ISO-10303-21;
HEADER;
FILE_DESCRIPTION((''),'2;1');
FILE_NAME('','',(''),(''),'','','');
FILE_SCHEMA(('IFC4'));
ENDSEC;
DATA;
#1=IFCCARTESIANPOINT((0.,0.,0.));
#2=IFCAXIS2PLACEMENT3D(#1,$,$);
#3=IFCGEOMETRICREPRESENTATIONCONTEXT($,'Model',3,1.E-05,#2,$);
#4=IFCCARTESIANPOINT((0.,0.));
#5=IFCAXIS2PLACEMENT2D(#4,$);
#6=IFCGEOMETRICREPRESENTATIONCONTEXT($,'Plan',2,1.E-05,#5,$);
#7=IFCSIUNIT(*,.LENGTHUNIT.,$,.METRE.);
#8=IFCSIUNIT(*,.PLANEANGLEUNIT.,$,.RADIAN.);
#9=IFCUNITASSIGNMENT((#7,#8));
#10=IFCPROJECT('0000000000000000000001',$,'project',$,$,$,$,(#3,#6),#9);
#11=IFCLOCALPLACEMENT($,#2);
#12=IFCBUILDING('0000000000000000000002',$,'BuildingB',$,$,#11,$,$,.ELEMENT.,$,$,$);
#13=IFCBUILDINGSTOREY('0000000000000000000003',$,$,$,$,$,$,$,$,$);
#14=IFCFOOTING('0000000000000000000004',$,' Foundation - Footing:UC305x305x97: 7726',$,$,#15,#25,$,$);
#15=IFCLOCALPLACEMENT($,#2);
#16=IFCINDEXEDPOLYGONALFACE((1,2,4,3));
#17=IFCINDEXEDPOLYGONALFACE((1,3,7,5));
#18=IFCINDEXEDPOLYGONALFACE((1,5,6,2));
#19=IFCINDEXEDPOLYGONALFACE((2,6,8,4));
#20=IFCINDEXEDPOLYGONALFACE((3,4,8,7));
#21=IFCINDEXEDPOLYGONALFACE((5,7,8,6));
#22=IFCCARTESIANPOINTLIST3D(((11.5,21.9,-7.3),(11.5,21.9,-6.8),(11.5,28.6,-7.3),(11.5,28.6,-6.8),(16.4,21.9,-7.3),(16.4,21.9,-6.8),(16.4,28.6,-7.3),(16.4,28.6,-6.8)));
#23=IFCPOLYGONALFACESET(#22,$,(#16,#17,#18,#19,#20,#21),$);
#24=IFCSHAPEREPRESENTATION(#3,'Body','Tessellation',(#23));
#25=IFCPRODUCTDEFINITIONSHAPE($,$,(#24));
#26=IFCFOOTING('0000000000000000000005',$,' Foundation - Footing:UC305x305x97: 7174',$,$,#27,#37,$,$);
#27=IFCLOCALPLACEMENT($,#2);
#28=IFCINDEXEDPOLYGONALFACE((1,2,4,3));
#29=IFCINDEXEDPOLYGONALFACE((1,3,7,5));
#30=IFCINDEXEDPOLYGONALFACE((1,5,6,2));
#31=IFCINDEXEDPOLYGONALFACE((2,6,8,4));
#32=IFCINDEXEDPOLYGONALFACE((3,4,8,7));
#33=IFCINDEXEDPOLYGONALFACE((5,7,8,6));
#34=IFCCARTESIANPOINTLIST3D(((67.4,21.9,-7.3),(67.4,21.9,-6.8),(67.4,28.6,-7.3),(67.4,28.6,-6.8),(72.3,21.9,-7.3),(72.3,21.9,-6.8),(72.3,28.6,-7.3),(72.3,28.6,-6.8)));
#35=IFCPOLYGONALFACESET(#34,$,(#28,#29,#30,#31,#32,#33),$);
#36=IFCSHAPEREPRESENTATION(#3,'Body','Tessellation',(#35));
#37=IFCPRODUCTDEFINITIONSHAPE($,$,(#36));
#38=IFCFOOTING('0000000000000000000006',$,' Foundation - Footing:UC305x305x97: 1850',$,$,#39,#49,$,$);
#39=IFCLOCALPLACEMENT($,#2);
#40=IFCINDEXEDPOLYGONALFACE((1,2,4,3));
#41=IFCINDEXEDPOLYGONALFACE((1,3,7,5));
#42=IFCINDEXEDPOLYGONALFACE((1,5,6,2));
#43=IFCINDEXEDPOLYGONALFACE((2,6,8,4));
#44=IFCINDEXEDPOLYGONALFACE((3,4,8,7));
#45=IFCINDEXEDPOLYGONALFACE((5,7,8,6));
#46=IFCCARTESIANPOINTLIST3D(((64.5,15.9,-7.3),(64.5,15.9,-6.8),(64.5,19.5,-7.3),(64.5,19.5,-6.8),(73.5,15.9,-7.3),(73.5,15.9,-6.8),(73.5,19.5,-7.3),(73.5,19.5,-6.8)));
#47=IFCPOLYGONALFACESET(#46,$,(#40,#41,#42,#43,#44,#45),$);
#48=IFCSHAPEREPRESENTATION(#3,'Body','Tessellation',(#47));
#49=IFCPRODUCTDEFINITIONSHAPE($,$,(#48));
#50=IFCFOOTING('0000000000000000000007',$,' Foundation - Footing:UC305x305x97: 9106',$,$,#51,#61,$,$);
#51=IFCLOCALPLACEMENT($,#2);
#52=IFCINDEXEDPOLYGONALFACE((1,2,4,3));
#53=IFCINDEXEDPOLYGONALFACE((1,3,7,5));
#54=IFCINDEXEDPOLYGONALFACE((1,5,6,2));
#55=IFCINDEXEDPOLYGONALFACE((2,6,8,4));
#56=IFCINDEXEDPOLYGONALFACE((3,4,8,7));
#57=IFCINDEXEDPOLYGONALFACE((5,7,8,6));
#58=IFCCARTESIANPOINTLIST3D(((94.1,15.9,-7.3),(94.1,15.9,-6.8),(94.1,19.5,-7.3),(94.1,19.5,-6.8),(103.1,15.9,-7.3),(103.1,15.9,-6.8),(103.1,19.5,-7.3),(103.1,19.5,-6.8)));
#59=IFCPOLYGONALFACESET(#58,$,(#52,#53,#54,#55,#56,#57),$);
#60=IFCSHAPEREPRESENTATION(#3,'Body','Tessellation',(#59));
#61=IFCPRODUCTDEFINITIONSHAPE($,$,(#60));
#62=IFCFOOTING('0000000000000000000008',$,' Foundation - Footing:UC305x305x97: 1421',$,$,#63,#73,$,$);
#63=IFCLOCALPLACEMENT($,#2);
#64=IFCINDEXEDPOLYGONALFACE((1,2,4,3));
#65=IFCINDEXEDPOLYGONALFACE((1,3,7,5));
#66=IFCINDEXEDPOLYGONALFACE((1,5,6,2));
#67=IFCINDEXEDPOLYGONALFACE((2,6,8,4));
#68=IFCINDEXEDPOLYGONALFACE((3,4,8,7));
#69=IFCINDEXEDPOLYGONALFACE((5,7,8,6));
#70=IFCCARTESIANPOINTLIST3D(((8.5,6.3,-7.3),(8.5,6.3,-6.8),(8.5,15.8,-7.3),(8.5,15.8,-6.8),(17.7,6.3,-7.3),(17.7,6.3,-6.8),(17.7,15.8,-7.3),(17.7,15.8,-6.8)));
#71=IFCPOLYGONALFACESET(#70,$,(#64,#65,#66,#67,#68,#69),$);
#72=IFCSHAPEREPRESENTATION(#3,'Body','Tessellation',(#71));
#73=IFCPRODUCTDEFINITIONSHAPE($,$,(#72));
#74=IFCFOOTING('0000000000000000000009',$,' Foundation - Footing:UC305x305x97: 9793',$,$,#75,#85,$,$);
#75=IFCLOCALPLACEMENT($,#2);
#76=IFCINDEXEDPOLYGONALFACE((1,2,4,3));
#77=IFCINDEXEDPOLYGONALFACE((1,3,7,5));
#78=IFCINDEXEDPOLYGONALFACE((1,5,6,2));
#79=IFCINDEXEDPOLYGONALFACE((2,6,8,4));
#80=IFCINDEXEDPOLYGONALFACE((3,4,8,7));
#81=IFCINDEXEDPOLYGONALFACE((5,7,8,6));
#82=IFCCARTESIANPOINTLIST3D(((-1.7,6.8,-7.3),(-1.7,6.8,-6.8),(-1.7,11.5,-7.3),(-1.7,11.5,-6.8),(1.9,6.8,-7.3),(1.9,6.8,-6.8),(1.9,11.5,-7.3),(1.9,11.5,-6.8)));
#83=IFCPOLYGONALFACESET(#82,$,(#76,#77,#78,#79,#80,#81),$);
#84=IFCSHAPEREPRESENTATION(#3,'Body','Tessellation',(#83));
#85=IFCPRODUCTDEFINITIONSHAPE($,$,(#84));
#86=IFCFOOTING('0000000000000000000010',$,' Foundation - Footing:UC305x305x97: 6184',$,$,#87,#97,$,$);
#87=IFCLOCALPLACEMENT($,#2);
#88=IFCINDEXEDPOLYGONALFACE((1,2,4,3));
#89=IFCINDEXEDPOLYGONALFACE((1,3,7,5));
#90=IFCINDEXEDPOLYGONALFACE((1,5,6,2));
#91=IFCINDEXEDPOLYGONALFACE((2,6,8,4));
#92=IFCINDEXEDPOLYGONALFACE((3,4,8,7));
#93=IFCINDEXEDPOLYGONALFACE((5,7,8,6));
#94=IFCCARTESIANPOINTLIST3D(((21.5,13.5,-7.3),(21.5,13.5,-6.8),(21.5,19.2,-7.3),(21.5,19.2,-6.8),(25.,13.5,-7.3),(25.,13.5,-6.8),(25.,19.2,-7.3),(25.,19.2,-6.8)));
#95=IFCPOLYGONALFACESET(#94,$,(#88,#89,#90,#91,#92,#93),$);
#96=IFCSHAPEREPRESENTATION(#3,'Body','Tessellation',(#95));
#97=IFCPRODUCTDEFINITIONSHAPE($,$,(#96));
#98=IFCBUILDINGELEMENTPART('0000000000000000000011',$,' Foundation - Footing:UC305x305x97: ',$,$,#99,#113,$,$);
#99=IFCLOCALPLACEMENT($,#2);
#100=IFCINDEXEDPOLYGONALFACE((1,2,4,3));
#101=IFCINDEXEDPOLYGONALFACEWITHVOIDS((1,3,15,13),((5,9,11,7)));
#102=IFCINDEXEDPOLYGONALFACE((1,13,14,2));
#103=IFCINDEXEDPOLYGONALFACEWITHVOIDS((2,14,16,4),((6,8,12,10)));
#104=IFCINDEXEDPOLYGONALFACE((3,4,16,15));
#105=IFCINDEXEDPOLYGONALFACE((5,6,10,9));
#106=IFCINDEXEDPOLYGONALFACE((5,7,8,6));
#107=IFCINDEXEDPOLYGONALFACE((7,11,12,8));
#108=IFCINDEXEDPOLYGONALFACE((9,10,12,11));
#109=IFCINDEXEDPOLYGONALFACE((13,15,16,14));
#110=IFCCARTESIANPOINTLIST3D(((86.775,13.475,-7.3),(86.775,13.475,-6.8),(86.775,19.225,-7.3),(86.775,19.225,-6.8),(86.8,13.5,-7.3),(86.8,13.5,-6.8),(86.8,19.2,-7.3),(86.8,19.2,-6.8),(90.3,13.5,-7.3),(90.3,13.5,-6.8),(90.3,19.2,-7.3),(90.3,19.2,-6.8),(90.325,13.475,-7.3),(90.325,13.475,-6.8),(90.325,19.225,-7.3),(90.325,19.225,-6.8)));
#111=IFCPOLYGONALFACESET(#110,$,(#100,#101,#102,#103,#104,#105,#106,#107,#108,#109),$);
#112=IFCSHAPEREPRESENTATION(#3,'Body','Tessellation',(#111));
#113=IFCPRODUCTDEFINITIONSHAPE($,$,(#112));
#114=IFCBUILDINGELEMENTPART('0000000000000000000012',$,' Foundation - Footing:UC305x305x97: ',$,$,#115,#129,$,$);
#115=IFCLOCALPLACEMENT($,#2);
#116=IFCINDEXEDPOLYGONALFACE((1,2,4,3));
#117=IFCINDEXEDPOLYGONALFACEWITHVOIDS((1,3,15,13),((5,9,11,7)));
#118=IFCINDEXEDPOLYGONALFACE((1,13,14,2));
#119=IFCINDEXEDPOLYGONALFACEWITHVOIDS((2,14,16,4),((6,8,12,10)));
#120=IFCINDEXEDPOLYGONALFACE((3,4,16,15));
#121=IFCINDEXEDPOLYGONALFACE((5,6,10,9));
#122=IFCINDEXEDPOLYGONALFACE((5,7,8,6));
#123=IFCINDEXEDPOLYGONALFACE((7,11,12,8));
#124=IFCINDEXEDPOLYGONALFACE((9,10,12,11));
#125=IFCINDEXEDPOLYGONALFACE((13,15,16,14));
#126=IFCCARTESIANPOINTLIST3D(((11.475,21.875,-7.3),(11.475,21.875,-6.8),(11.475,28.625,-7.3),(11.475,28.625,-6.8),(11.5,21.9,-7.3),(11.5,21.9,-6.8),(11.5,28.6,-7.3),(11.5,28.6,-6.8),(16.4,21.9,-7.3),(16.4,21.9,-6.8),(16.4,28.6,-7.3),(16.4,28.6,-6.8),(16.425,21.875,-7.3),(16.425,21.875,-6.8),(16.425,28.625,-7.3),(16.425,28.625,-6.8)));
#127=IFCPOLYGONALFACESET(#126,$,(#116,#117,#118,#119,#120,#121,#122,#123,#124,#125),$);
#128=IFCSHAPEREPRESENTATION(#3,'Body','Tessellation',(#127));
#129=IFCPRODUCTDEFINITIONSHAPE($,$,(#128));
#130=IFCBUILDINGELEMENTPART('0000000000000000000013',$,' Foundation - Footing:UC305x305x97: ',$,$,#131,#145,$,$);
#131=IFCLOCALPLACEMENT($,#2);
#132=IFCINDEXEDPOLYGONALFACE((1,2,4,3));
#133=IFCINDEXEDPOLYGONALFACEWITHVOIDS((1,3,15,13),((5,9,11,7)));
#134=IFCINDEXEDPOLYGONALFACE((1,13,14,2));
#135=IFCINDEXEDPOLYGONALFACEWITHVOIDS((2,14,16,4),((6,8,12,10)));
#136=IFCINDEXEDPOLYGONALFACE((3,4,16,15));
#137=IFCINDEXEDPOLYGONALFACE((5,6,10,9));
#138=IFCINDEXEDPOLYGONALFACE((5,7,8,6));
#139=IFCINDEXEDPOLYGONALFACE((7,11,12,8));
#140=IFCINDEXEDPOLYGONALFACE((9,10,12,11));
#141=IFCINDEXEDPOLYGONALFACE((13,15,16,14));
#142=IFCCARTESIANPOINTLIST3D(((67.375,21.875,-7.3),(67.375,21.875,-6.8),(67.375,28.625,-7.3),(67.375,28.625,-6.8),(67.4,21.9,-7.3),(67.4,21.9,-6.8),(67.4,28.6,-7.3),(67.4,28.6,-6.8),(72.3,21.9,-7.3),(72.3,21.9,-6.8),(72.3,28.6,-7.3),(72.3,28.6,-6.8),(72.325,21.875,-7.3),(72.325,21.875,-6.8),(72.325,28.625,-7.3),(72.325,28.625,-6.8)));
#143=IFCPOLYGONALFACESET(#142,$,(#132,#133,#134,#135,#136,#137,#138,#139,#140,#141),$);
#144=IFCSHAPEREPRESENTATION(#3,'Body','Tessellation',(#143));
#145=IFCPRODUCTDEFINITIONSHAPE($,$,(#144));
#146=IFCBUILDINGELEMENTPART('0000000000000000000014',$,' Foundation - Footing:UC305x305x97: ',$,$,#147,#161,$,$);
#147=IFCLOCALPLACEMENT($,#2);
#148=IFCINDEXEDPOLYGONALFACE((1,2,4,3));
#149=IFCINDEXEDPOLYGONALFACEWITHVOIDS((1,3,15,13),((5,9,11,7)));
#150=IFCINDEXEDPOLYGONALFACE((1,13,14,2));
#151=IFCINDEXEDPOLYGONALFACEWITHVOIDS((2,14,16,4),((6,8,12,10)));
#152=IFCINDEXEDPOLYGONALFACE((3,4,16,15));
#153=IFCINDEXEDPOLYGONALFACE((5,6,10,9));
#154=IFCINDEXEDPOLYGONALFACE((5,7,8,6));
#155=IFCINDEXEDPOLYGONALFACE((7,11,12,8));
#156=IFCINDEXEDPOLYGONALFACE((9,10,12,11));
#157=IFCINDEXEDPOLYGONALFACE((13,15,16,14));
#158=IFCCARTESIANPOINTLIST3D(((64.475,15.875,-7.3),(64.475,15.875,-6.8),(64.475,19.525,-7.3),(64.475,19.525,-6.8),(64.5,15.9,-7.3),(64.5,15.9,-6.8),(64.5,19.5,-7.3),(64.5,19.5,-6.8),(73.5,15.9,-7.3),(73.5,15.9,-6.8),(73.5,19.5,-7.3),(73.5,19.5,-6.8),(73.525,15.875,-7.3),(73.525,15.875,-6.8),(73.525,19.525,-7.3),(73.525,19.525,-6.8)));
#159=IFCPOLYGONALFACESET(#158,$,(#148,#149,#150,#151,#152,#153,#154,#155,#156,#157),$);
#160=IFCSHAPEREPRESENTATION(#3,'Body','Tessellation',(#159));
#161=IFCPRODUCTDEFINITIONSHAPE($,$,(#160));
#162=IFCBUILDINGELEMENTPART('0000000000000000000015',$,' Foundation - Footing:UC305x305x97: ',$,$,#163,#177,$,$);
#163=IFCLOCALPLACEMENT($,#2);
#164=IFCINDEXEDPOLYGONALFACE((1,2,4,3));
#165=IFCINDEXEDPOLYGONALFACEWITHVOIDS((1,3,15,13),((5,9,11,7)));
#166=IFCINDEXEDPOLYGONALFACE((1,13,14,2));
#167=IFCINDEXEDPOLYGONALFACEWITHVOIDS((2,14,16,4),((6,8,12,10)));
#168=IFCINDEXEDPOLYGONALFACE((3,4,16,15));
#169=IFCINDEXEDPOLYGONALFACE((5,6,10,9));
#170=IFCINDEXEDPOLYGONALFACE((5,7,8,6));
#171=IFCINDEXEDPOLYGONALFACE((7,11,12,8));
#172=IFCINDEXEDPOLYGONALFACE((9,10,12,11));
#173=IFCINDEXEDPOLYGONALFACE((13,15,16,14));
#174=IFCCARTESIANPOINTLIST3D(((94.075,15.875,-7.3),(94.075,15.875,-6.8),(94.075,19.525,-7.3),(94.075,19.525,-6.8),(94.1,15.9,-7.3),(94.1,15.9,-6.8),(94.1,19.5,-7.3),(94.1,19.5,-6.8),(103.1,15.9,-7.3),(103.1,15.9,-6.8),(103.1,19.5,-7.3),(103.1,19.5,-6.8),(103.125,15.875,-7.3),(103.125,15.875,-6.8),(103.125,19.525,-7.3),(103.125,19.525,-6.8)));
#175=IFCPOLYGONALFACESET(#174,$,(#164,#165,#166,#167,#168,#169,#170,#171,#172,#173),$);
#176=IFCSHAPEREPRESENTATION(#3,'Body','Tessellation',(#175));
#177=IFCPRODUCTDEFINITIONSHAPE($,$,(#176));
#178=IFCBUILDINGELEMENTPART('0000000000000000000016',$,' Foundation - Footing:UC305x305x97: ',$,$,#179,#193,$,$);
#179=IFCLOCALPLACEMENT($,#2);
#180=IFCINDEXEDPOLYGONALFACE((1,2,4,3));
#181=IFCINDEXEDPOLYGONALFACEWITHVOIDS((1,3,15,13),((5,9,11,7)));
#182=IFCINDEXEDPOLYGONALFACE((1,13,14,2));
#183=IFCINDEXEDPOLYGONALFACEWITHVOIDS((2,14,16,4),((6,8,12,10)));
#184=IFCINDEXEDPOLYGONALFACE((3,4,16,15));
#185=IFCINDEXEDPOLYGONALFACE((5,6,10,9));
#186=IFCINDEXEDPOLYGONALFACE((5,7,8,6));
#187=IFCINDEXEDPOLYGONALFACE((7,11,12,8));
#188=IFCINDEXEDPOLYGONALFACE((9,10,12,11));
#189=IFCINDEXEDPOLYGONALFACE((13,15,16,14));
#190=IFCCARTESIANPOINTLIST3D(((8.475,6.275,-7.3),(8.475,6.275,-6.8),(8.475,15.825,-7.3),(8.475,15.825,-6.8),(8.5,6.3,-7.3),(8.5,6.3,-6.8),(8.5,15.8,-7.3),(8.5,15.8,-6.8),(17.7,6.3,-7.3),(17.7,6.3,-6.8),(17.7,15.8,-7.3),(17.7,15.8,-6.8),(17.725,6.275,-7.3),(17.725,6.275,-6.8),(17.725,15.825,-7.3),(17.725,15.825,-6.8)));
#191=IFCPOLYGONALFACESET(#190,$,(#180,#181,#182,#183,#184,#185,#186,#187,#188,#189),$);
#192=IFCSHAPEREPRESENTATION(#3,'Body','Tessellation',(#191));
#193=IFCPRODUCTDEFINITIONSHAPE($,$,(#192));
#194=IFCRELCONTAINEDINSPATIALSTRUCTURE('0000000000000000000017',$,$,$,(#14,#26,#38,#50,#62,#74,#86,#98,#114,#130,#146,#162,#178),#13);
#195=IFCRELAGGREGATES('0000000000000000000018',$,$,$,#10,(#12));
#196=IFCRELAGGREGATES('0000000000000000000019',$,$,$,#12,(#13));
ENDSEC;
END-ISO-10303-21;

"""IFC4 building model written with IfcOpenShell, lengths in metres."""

from ifc_helpers import new_model, si_unit, origin, origin_2d, place, context, project, spatial, polyline, outline, extrude, element, save


model = new_model("IFC4")

# Units and contexts
model_context = context("Model", 3, precision=1e-05, world=origin())
plan_context = context("Plan", 2, precision=1e-05, world=origin_2d())
ifc_project = project(units=[si_unit("LENGTHUNIT", "METRE"), si_unit("PLANEANGLEUNIT", "RADIAN")], contexts=[model_context, plan_context])

# Building, storey
building_placement = place(None, origin())
building = spatial("IfcBuilding", under=ifc_project, at=building_placement, Name="BuildingB", CompositionType="ELEMENT")
storey = spatial("IfcBuildingStorey", under=building)

# Footings
element("IfcFooting", 1, inside=storey, Name=" Foundation - Footing:UC305x305x97: 7726", context=model_context, shape_type="SweptSolid", body=[
    extrude(outline(polyline([(16.4, 21.9, -7.3), (16.4, 28.6, -7.3), (11.5, 28.6, -7.3), (11.5, 21.9, -7.3), (16.4, 21.9, -7.3)])), None, (0.0, 0.0, 1.0), 0.5),
])
element("IfcFooting", 2, inside=storey, Name=" Foundation - Footing:UC305x305x97: 7174", context=model_context, shape_type="SweptSolid", body=[
    extrude(outline(polyline([(67.4, 21.9, -7.3), (67.4, 28.6, -7.3), (72.3, 28.6, -7.3), (72.3, 21.9, -7.3), (67.4, 21.9, -7.3)])), None, (0.0, 0.0, 1.0), 0.5),
])
element("IfcFooting", 3, inside=storey, Name=" Foundation - Footing:UC305x305x97: 1850", context=model_context, shape_type="SweptSolid", body=[
    extrude(outline(polyline([(64.5, 19.5, -7.3), (73.5, 19.5, -7.3), (73.5, 15.9, -7.3), (64.5, 15.9, -7.3), (64.5, 19.5, -7.3)])), None, (0.0, 0.0, 1.0), 0.5),
])
element("IfcFooting", 4, inside=storey, Name=" Foundation - Footing:UC305x305x97: 9106", context=model_context, shape_type="SweptSolid", body=[
    extrude(outline(polyline([(94.1, 19.5, -7.3), (103.1, 19.5, -7.3), (103.1, 15.9, -7.3), (94.1, 15.9, -7.3), (94.1, 19.5, -7.3)])), None, (0.0, 0.0, 1.0), 0.5),
])
element("IfcFooting", 5, inside=storey, Name=" Foundation - Footing:UC305x305x97: 1421", context=model_context, shape_type="SweptSolid", body=[
    extrude(outline(polyline([(8.5, 15.8, -7.3), (17.7, 15.8, -7.3), (17.7, 6.3, -7.3), (8.5, 6.3, -7.3), (8.5, 15.8, -7.3)])), None, (0.0, 0.0, 1.0), 0.5),
])
element("IfcFooting", 6, inside=storey, Name=" Foundation - Footing:UC305x305x97: 9793", context=model_context, shape_type="SweptSolid", body=[
    extrude(outline(polyline([(1.9, 11.5, -7.3), (-1.7, 11.5, -7.3), (-1.7, 6.8, -7.3), (1.9, 6.8, -7.3), (1.9, 11.5, -7.3)])), None, (0.0, 0.0, 1.0), 0.5),
])
element("IfcFooting", 7, inside=storey, Name=" Foundation - Footing:UC305x305x97: 6184", context=model_context, shape_type="SweptSolid", body=[
    extrude(outline(polyline([(25.0, 19.2, -7.3), (21.5, 19.2, -7.3), (21.5, 13.5, -7.3), (25.0, 13.5, -7.3), (25.0, 19.2, -7.3)])), None, (0.0, 0.0, 1.0), 0.5),
])

# Building element parts, openings
building_element_part_1 = element("IfcBuildingElementPart", 8, inside=storey, Name=" Foundation - Footing:UC305x305x97: ", context=model_context, shape_type="SweptSolid", body=[
    extrude(outline(polyline([(86.775, 19.225, -7.3), (90.325, 19.225, -7.3), (90.325, 13.475, -7.3), (86.775, 13.475, -7.3), (86.775, 19.225, -7.3)])), None, (0.0, 0.0, 1.0), 0.5),
])
element("IfcOpeningElement", 9, inside=storey, cuts=building_element_part_1, context=model_context, shape_type="SweptSolid", body=[
    extrude(outline(polyline([(86.8, 19.2, -7.3), (90.3, 19.2, -7.3), (90.3, 13.5, -7.3), (86.8, 13.5, -7.3), (86.8, 19.2, -7.3)])), None, (0.0, 0.0, 1.0), 0.5),
])
building_element_part_2 = element("IfcBuildingElementPart", 10, inside=storey, Name=" Foundation - Footing:UC305x305x97: ", context=model_context, shape_type="SweptSolid", body=[
    extrude(outline(polyline([(16.425, 21.875, -7.3), (16.425, 28.625, -7.3), (11.475, 28.625, -7.3), (11.475, 21.875, -7.3), (16.425, 21.875, -7.3)])), None, (0.0, 0.0, 1.0), 0.5),
])
element("IfcOpeningElement", 11, inside=storey, cuts=building_element_part_2, context=model_context, shape_type="SweptSolid", body=[
    extrude(outline(polyline([(16.4, 21.9, -7.3), (16.4, 28.6, -7.3), (11.5, 28.6, -7.3), (11.5, 21.9, -7.3), (16.4, 21.9, -7.3)])), None, (0.0, 0.0, 1.0), 0.5),
])
building_element_part_3 = element("IfcBuildingElementPart", 12, inside=storey, Name=" Foundation - Footing:UC305x305x97: ", context=model_context, shape_type="SweptSolid", body=[
    extrude(outline(polyline([(67.375, 21.875, -7.3), (67.375, 28.625, -7.3), (72.325, 28.625, -7.3), (72.325, 21.875, -7.3), (67.375, 21.875, -7.3)])), None, (0.0, 0.0, 1.0), 0.5),
])
element("IfcOpeningElement", 13, inside=storey, cuts=building_element_part_3, context=model_context, shape_type="SweptSolid", body=[
    extrude(outline(polyline([(67.4, 21.9, -7.3), (67.4, 28.6, -7.3), (72.3, 28.6, -7.3), (72.3, 21.9, -7.3), (67.4, 21.9, -7.3)])), None, (0.0, 0.0, 1.0), 0.5),
])
building_element_part_4 = element("IfcBuildingElementPart", 14, inside=storey, Name=" Foundation - Footing:UC305x305x97: ", context=model_context, shape_type="SweptSolid", body=[
    extrude(outline(polyline([(64.475, 19.525, -7.3), (73.525, 19.525, -7.3), (73.525, 15.875, -7.3), (64.475, 15.875, -7.3), (64.475, 19.525, -7.3)])), None, (0.0, 0.0, 1.0), 0.5),
])
element("IfcOpeningElement", 15, inside=storey, cuts=building_element_part_4, context=model_context, shape_type="SweptSolid", body=[
    extrude(outline(polyline([(64.5, 19.5, -7.3), (73.5, 19.5, -7.3), (73.5, 15.9, -7.3), (64.5, 15.9, -7.3), (64.5, 19.5, -7.3)])), None, (0.0, 0.0, 1.0), 0.5),
])
building_element_part_5 = element("IfcBuildingElementPart", 16, inside=storey, Name=" Foundation - Footing:UC305x305x97: ", context=model_context, shape_type="SweptSolid", body=[
    extrude(outline(polyline([(94.075, 19.525, -7.3), (103.125, 19.525, -7.3), (103.125, 15.875, -7.3), (94.075, 15.875, -7.3), (94.075, 19.525, -7.3)])), None, (0.0, 0.0, 1.0), 0.5),
])
element("IfcOpeningElement", 17, inside=storey, cuts=building_element_part_5, context=model_context, shape_type="SweptSolid", body=[
    extrude(outline(polyline([(94.1, 19.5, -7.3), (103.1, 19.5, -7.3), (103.1, 15.9, -7.3), (94.1, 15.9, -7.3), (94.1, 19.5, -7.3)])), None, (0.0, 0.0, 1.0), 0.5),
])
building_element_part_6 = element("IfcBuildingElementPart", 18, inside=storey, Name=" Foundation - Footing:UC305x305x97: ", context=model_context, shape_type="SweptSolid", body=[
    extrude(outline(polyline([(8.475, 15.825, -7.3), (17.725, 15.825, -7.3), (17.725, 6.275, -7.3), (8.475, 6.275, -7.3), (8.475, 15.825, -7.3)])), None, (0.0, 0.0, 1.0), 0.5),
])
element("IfcOpeningElement", 19, inside=storey, cuts=building_element_part_6, context=model_context, shape_type="SweptSolid", body=[
    extrude(outline(polyline([(8.5, 15.8, -7.3), (17.7, 15.8, -7.3), (17.7, 6.3, -7.3), (8.5, 6.3, -7.3), (8.5, 15.8, -7.3)])), None, (0.0, 0.0, 1.0), 0.5),
])

save(model, "model.ifc")
